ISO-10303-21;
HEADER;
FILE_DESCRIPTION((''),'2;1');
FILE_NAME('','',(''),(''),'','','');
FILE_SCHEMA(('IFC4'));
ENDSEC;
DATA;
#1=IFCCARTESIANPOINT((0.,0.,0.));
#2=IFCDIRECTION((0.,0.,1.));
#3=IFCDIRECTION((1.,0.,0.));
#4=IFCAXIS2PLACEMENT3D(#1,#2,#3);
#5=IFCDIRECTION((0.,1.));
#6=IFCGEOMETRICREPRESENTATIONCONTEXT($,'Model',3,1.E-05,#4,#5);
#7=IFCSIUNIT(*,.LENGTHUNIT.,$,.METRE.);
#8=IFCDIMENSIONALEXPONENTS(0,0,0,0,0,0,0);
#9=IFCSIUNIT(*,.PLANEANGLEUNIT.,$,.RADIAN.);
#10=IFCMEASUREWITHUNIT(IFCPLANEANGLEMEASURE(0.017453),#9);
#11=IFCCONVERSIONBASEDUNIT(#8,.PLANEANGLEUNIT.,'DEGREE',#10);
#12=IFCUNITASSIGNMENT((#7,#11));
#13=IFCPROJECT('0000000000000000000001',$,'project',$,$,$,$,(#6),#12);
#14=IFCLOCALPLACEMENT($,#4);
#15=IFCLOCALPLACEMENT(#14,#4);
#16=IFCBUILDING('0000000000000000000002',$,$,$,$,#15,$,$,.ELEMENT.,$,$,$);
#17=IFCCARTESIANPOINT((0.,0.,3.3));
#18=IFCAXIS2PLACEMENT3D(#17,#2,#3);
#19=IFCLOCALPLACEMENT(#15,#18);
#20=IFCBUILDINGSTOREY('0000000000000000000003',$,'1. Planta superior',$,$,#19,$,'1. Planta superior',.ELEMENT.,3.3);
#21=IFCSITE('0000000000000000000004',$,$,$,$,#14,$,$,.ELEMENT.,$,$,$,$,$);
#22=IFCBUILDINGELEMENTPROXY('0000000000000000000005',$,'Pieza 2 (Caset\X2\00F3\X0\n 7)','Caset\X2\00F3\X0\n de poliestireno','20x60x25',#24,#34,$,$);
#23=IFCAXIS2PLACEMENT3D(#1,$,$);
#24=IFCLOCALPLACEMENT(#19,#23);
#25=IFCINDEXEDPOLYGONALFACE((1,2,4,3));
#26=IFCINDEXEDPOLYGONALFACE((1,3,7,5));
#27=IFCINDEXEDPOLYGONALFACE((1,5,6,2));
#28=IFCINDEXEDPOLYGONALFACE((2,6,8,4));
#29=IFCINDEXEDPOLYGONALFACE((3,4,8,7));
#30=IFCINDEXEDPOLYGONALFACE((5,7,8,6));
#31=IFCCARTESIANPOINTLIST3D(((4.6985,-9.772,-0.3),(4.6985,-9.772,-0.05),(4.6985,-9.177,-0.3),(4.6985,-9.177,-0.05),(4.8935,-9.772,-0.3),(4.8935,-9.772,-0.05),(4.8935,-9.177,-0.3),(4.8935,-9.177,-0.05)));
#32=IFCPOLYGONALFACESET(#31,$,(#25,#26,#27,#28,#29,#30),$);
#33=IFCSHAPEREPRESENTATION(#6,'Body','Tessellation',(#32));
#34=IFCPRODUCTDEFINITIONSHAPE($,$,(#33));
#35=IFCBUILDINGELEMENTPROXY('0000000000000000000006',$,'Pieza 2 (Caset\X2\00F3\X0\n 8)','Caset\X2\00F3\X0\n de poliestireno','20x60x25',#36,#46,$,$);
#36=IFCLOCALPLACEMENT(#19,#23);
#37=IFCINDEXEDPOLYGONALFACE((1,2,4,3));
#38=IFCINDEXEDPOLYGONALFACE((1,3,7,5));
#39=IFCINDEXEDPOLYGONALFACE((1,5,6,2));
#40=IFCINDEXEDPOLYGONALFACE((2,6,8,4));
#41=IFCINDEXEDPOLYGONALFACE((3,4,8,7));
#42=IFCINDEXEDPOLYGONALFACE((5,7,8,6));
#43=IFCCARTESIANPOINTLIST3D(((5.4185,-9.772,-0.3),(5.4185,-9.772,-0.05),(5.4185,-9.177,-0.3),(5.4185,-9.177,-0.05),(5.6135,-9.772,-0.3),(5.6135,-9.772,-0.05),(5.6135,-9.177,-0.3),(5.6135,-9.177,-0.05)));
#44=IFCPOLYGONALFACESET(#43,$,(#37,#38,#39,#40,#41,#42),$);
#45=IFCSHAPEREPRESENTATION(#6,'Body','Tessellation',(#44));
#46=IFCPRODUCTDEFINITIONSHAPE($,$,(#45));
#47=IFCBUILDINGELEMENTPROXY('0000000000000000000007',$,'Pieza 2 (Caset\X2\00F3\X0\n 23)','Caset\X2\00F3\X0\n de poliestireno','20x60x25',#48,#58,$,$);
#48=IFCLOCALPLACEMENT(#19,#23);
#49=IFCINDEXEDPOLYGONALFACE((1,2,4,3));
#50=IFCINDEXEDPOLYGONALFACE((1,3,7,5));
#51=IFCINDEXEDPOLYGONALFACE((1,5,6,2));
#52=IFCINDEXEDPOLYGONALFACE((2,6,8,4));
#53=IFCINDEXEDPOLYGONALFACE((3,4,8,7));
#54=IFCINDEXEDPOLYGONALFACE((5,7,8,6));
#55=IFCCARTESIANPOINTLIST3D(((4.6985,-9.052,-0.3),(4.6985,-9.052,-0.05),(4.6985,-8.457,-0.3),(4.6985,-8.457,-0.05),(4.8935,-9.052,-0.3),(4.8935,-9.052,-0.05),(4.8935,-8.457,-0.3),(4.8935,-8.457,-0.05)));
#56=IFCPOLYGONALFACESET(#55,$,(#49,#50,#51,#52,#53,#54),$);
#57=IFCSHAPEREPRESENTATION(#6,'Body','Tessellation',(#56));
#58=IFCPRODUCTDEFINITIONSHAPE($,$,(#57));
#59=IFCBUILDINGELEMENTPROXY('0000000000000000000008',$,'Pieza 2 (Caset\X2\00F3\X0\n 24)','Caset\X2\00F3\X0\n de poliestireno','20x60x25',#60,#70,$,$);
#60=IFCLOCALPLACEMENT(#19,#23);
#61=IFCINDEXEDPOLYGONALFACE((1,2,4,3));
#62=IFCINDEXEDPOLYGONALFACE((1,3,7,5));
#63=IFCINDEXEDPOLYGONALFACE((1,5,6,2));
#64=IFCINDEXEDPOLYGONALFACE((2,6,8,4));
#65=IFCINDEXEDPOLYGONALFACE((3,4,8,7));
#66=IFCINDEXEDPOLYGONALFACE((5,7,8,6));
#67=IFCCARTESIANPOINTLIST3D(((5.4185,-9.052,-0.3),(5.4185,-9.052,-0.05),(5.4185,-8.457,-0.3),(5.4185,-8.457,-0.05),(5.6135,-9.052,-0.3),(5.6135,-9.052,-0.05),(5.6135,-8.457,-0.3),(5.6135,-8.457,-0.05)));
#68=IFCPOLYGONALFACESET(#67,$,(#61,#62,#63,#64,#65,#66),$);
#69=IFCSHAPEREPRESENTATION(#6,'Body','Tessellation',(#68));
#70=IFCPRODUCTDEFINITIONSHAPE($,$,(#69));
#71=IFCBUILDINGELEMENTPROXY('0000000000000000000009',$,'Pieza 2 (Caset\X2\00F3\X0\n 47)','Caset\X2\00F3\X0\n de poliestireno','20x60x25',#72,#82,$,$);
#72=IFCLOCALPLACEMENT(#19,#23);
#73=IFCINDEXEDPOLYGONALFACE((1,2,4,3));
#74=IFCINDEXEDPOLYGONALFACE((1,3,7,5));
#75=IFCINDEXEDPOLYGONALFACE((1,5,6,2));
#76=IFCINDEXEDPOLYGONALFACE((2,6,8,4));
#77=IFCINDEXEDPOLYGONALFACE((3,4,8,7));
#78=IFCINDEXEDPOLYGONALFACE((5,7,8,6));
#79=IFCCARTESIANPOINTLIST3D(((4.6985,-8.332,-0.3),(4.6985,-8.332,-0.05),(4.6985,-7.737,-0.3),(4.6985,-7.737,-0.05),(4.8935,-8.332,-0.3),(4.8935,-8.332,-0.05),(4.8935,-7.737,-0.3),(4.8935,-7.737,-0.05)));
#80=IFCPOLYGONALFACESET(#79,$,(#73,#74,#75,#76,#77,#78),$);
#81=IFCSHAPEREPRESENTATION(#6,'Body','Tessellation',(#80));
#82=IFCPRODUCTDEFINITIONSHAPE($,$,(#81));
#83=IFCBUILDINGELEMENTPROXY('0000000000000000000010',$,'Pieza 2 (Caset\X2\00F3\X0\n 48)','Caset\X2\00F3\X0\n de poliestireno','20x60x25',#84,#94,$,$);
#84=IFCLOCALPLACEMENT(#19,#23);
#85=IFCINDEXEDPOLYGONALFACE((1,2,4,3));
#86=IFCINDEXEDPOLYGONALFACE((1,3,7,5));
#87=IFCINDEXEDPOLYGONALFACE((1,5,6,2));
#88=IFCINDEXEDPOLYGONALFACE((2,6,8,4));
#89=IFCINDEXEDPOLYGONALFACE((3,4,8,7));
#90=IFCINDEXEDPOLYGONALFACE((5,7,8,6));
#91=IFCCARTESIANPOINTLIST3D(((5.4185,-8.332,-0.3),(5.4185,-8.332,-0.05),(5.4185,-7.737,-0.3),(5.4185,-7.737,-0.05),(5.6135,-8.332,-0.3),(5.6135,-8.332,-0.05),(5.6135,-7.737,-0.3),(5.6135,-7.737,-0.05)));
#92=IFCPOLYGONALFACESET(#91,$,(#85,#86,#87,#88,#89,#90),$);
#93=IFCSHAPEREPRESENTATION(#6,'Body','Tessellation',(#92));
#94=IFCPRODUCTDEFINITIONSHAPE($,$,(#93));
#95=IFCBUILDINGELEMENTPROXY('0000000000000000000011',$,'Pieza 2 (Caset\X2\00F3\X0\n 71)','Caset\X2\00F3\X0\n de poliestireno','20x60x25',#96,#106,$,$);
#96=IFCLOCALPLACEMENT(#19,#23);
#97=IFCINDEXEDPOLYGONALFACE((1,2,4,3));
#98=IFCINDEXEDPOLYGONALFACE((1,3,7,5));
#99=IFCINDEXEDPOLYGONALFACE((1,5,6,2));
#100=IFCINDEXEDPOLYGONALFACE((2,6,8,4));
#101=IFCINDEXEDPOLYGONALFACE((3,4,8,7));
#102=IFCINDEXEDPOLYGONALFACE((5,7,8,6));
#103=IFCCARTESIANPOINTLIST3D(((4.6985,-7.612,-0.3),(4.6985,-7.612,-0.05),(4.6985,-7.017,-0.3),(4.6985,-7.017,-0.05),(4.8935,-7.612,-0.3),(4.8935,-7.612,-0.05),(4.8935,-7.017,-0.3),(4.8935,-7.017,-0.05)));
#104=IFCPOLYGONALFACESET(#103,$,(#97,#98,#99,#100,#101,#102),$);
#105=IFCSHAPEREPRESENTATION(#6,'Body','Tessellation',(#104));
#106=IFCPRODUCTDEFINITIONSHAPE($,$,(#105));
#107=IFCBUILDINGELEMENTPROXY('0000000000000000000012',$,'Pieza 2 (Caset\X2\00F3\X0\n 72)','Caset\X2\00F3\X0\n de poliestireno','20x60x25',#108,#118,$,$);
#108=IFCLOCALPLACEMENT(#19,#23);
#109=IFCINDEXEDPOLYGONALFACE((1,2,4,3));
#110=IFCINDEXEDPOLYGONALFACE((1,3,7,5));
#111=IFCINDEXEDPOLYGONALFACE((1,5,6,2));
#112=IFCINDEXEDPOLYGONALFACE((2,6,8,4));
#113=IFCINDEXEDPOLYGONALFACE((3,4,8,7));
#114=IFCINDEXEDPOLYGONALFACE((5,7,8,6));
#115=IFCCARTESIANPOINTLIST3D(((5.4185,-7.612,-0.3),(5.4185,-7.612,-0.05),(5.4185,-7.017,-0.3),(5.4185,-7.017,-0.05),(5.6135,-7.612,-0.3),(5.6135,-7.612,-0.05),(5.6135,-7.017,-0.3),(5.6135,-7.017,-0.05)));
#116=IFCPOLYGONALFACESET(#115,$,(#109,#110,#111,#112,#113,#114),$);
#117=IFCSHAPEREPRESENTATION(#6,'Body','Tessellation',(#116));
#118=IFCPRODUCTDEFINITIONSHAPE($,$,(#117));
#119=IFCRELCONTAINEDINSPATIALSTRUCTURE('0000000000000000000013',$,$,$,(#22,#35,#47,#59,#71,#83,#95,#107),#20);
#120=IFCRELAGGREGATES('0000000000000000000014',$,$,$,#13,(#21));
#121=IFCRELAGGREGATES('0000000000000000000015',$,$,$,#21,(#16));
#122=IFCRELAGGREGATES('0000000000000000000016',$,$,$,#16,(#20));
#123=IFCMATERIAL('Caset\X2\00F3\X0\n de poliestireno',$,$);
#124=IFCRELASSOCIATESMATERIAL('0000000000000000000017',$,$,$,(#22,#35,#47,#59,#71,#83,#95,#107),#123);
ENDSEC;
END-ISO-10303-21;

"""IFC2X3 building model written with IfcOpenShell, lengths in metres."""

from ifc_helpers import new_model, entity, si_unit, converted_unit, direction, frame, origin_with_axes, origin_2d_with_axis, place, context, project, spatial, rectangle, extrude, source, transform, mapped, material, element, save


model = new_model("IFC2X3")

# Units and contexts
model_context = context("Model", 3, precision=1e-05, world=origin_with_axes(), true_north=direction((0.0, 1.0)))
ifc_project = project(units=[si_unit("LENGTHUNIT", "METRE"), converted_unit("PLANEANGLEUNIT", "DEGREE", entity("IfcPlaneAngleMeasure", 0.017453), si_unit("PLANEANGLEUNIT", "RADIAN"), dimensions=[0, 0, 0, 0, 0, 0, 0])], contexts=[model_context])

# Site, building, storey
site_placement = place(None, origin_with_axes())
site = spatial("IfcSite", under=ifc_project, at=site_placement, CompositionType="ELEMENT")
building_placement = place(site_placement, origin_with_axes())
building = spatial("IfcBuilding", under=site, at=building_placement, CompositionType="ELEMENT")
storey_placement = place(building_placement, frame((0.0, 0.0, 3.3), z_axis=(0.0, 0.0, 1.0), x_axis=(1.0, 0.0, 0.0)))
storey = spatial("IfcBuildingStorey", under=building, at=storey_placement, Name="1. Planta superior", LongName="1. Planta superior", CompositionType="ELEMENT", Elevation=3.3)

# Building element proxies
ifc_material = material(Name="Casetón de poliestireno")
shared_shape = source(origin_with_axes(), model_context, "Body", "SweptSolid", [
    extrude(rectangle(XDim=0.195, YDim=0.25, at=origin_2d_with_axis()), origin_with_axes(), (0.0, 0.0, 1.0), 0.595),
])
placement_1 = place(storey_placement, frame((4.796, -9.772, -0.175), z_axis=(0.0, 1.0, 0.0), x_axis=(-1.0, 0.0, 0.0)))
for number, where, z_axis, x_axis, name in (
    (1, (0.0, 0.0, 0.0), (0.0, 0.0, 1.0), (1.0, 0.0, 0.0), "Pieza 2 (Casetón 7)"),
):
    element("IfcBuildingElementProxy", number, at=place(placement_1, frame(where, z_axis=z_axis, x_axis=x_axis)), inside=storey, material=ifc_material, Name=name, Description="Casetón de poliestireno", ObjectType="20x60x25", context=model_context, shape_type="MappedRepresentation", body=[
        mapped(shared_shape, transform((0.0, 0.0, 0.0), x_axis=(1.0, 0.0, 0.0), y_axis=(0.0, 1.0, 0.0), z_axis=(0.0, 0.0, 1.0))),
    ])
placement_2 = place(storey_placement, frame((5.516, -9.772, -0.175), z_axis=(0.0, 1.0, 0.0), x_axis=(-1.0, 0.0, 0.0)))
for number, where, z_axis, x_axis, name in (
    (2, (0.0, 0.0, 0.0), (0.0, 0.0, 1.0), (1.0, 0.0, 0.0), "Pieza 2 (Casetón 8)"),
):
    element("IfcBuildingElementProxy", number, at=place(placement_2, frame(where, z_axis=z_axis, x_axis=x_axis)), inside=storey, material=ifc_material, Name=name, Description="Casetón de poliestireno", ObjectType="20x60x25", context=model_context, shape_type="MappedRepresentation", body=[
        mapped(shared_shape, transform((0.0, 0.0, 0.0), x_axis=(1.0, 0.0, 0.0), y_axis=(0.0, 1.0, 0.0), z_axis=(0.0, 0.0, 1.0))),
    ])
placement_3 = place(storey_placement, frame((4.796, -9.052, -0.175), z_axis=(0.0, 1.0, 0.0), x_axis=(-1.0, 0.0, 0.0)))
for number, where, z_axis, x_axis, name in (
    (3, (0.0, 0.0, 0.0), (0.0, 0.0, 1.0), (1.0, 0.0, 0.0), "Pieza 2 (Casetón 23)"),
):
    element("IfcBuildingElementProxy", number, at=place(placement_3, frame(where, z_axis=z_axis, x_axis=x_axis)), inside=storey, material=ifc_material, Name=name, Description="Casetón de poliestireno", ObjectType="20x60x25", context=model_context, shape_type="MappedRepresentation", body=[
        mapped(shared_shape, transform((0.0, 0.0, 0.0), x_axis=(1.0, 0.0, 0.0), y_axis=(0.0, 1.0, 0.0), z_axis=(0.0, 0.0, 1.0))),
    ])
placement_4 = place(storey_placement, frame((5.516, -9.052, -0.175), z_axis=(0.0, 1.0, 0.0), x_axis=(-1.0, 0.0, 0.0)))
for number, where, z_axis, x_axis, name in (
    (4, (0.0, 0.0, 0.0), (0.0, 0.0, 1.0), (1.0, 0.0, 0.0), "Pieza 2 (Casetón 24)"),
):
    element("IfcBuildingElementProxy", number, at=place(placement_4, frame(where, z_axis=z_axis, x_axis=x_axis)), inside=storey, material=ifc_material, Name=name, Description="Casetón de poliestireno", ObjectType="20x60x25", context=model_context, shape_type="MappedRepresentation", body=[
        mapped(shared_shape, transform((0.0, 0.0, 0.0), x_axis=(1.0, 0.0, 0.0), y_axis=(0.0, 1.0, 0.0), z_axis=(0.0, 0.0, 1.0))),
    ])
placement_5 = place(storey_placement, frame((4.796, -8.332, -0.175), z_axis=(0.0, 1.0, 0.0), x_axis=(-1.0, 0.0, 0.0)))
for number, where, z_axis, x_axis, name in (
    (5, (0.0, 0.0, 0.0), (0.0, 0.0, 1.0), (1.0, 0.0, 0.0), "Pieza 2 (Casetón 47)"),
):
    element("IfcBuildingElementProxy", number, at=place(placement_5, frame(where, z_axis=z_axis, x_axis=x_axis)), inside=storey, material=ifc_material, Name=name, Description="Casetón de poliestireno", ObjectType="20x60x25", context=model_context, shape_type="MappedRepresentation", body=[
        mapped(shared_shape, transform((0.0, 0.0, 0.0), x_axis=(1.0, 0.0, 0.0), y_axis=(0.0, 1.0, 0.0), z_axis=(0.0, 0.0, 1.0))),
    ])
placement_6 = place(storey_placement, frame((5.516, -8.332, -0.175), z_axis=(0.0, 1.0, 0.0), x_axis=(-1.0, 0.0, 0.0)))
for number, where, z_axis, x_axis, name in (
    (6, (0.0, 0.0, 0.0), (0.0, 0.0, 1.0), (1.0, 0.0, 0.0), "Pieza 2 (Casetón 48)"),
):
    element("IfcBuildingElementProxy", number, at=place(placement_6, frame(where, z_axis=z_axis, x_axis=x_axis)), inside=storey, material=ifc_material, Name=name, Description="Casetón de poliestireno", ObjectType="20x60x25", context=model_context, shape_type="MappedRepresentation", body=[
        mapped(shared_shape, transform((0.0, 0.0, 0.0), x_axis=(1.0, 0.0, 0.0), y_axis=(0.0, 1.0, 0.0), z_axis=(0.0, 0.0, 1.0))),
    ])
placement_7 = place(storey_placement, frame((4.796, -7.612, -0.175), z_axis=(0.0, 1.0, 0.0), x_axis=(-1.0, 0.0, 0.0)))
for number, where, z_axis, x_axis, name in (
    (7, (0.0, 0.0, 0.0), (0.0, 0.0, 1.0), (1.0, 0.0, 0.0), "Pieza 2 (Casetón 71)"),
):
    element("IfcBuildingElementProxy", number, at=place(placement_7, frame(where, z_axis=z_axis, x_axis=x_axis)), inside=storey, material=ifc_material, Name=name, Description="Casetón de poliestireno", ObjectType="20x60x25", context=model_context, shape_type="MappedRepresentation", body=[
        mapped(shared_shape, transform((0.0, 0.0, 0.0), x_axis=(1.0, 0.0, 0.0), y_axis=(0.0, 1.0, 0.0), z_axis=(0.0, 0.0, 1.0))),
    ])
placement_8 = place(storey_placement, frame((5.516, -7.612, -0.175), z_axis=(0.0, 1.0, 0.0), x_axis=(-1.0, 0.0, 0.0)))
for number, where, z_axis, x_axis, name in (
    (8, (0.0, 0.0, 0.0), (0.0, 0.0, 1.0), (1.0, 0.0, 0.0), "Pieza 2 (Casetón 72)"),
):
    element("IfcBuildingElementProxy", number, at=place(placement_8, frame(where, z_axis=z_axis, x_axis=x_axis)), inside=storey, material=ifc_material, Name=name, Description="Casetón de poliestireno", ObjectType="20x60x25", context=model_context, shape_type="MappedRepresentation", body=[
        mapped(shared_shape, transform((0.0, 0.0, 0.0), x_axis=(1.0, 0.0, 0.0), y_axis=(0.0, 1.0, 0.0), z_axis=(0.0, 0.0, 1.0))),
    ])

save(model, "model.ifc")
